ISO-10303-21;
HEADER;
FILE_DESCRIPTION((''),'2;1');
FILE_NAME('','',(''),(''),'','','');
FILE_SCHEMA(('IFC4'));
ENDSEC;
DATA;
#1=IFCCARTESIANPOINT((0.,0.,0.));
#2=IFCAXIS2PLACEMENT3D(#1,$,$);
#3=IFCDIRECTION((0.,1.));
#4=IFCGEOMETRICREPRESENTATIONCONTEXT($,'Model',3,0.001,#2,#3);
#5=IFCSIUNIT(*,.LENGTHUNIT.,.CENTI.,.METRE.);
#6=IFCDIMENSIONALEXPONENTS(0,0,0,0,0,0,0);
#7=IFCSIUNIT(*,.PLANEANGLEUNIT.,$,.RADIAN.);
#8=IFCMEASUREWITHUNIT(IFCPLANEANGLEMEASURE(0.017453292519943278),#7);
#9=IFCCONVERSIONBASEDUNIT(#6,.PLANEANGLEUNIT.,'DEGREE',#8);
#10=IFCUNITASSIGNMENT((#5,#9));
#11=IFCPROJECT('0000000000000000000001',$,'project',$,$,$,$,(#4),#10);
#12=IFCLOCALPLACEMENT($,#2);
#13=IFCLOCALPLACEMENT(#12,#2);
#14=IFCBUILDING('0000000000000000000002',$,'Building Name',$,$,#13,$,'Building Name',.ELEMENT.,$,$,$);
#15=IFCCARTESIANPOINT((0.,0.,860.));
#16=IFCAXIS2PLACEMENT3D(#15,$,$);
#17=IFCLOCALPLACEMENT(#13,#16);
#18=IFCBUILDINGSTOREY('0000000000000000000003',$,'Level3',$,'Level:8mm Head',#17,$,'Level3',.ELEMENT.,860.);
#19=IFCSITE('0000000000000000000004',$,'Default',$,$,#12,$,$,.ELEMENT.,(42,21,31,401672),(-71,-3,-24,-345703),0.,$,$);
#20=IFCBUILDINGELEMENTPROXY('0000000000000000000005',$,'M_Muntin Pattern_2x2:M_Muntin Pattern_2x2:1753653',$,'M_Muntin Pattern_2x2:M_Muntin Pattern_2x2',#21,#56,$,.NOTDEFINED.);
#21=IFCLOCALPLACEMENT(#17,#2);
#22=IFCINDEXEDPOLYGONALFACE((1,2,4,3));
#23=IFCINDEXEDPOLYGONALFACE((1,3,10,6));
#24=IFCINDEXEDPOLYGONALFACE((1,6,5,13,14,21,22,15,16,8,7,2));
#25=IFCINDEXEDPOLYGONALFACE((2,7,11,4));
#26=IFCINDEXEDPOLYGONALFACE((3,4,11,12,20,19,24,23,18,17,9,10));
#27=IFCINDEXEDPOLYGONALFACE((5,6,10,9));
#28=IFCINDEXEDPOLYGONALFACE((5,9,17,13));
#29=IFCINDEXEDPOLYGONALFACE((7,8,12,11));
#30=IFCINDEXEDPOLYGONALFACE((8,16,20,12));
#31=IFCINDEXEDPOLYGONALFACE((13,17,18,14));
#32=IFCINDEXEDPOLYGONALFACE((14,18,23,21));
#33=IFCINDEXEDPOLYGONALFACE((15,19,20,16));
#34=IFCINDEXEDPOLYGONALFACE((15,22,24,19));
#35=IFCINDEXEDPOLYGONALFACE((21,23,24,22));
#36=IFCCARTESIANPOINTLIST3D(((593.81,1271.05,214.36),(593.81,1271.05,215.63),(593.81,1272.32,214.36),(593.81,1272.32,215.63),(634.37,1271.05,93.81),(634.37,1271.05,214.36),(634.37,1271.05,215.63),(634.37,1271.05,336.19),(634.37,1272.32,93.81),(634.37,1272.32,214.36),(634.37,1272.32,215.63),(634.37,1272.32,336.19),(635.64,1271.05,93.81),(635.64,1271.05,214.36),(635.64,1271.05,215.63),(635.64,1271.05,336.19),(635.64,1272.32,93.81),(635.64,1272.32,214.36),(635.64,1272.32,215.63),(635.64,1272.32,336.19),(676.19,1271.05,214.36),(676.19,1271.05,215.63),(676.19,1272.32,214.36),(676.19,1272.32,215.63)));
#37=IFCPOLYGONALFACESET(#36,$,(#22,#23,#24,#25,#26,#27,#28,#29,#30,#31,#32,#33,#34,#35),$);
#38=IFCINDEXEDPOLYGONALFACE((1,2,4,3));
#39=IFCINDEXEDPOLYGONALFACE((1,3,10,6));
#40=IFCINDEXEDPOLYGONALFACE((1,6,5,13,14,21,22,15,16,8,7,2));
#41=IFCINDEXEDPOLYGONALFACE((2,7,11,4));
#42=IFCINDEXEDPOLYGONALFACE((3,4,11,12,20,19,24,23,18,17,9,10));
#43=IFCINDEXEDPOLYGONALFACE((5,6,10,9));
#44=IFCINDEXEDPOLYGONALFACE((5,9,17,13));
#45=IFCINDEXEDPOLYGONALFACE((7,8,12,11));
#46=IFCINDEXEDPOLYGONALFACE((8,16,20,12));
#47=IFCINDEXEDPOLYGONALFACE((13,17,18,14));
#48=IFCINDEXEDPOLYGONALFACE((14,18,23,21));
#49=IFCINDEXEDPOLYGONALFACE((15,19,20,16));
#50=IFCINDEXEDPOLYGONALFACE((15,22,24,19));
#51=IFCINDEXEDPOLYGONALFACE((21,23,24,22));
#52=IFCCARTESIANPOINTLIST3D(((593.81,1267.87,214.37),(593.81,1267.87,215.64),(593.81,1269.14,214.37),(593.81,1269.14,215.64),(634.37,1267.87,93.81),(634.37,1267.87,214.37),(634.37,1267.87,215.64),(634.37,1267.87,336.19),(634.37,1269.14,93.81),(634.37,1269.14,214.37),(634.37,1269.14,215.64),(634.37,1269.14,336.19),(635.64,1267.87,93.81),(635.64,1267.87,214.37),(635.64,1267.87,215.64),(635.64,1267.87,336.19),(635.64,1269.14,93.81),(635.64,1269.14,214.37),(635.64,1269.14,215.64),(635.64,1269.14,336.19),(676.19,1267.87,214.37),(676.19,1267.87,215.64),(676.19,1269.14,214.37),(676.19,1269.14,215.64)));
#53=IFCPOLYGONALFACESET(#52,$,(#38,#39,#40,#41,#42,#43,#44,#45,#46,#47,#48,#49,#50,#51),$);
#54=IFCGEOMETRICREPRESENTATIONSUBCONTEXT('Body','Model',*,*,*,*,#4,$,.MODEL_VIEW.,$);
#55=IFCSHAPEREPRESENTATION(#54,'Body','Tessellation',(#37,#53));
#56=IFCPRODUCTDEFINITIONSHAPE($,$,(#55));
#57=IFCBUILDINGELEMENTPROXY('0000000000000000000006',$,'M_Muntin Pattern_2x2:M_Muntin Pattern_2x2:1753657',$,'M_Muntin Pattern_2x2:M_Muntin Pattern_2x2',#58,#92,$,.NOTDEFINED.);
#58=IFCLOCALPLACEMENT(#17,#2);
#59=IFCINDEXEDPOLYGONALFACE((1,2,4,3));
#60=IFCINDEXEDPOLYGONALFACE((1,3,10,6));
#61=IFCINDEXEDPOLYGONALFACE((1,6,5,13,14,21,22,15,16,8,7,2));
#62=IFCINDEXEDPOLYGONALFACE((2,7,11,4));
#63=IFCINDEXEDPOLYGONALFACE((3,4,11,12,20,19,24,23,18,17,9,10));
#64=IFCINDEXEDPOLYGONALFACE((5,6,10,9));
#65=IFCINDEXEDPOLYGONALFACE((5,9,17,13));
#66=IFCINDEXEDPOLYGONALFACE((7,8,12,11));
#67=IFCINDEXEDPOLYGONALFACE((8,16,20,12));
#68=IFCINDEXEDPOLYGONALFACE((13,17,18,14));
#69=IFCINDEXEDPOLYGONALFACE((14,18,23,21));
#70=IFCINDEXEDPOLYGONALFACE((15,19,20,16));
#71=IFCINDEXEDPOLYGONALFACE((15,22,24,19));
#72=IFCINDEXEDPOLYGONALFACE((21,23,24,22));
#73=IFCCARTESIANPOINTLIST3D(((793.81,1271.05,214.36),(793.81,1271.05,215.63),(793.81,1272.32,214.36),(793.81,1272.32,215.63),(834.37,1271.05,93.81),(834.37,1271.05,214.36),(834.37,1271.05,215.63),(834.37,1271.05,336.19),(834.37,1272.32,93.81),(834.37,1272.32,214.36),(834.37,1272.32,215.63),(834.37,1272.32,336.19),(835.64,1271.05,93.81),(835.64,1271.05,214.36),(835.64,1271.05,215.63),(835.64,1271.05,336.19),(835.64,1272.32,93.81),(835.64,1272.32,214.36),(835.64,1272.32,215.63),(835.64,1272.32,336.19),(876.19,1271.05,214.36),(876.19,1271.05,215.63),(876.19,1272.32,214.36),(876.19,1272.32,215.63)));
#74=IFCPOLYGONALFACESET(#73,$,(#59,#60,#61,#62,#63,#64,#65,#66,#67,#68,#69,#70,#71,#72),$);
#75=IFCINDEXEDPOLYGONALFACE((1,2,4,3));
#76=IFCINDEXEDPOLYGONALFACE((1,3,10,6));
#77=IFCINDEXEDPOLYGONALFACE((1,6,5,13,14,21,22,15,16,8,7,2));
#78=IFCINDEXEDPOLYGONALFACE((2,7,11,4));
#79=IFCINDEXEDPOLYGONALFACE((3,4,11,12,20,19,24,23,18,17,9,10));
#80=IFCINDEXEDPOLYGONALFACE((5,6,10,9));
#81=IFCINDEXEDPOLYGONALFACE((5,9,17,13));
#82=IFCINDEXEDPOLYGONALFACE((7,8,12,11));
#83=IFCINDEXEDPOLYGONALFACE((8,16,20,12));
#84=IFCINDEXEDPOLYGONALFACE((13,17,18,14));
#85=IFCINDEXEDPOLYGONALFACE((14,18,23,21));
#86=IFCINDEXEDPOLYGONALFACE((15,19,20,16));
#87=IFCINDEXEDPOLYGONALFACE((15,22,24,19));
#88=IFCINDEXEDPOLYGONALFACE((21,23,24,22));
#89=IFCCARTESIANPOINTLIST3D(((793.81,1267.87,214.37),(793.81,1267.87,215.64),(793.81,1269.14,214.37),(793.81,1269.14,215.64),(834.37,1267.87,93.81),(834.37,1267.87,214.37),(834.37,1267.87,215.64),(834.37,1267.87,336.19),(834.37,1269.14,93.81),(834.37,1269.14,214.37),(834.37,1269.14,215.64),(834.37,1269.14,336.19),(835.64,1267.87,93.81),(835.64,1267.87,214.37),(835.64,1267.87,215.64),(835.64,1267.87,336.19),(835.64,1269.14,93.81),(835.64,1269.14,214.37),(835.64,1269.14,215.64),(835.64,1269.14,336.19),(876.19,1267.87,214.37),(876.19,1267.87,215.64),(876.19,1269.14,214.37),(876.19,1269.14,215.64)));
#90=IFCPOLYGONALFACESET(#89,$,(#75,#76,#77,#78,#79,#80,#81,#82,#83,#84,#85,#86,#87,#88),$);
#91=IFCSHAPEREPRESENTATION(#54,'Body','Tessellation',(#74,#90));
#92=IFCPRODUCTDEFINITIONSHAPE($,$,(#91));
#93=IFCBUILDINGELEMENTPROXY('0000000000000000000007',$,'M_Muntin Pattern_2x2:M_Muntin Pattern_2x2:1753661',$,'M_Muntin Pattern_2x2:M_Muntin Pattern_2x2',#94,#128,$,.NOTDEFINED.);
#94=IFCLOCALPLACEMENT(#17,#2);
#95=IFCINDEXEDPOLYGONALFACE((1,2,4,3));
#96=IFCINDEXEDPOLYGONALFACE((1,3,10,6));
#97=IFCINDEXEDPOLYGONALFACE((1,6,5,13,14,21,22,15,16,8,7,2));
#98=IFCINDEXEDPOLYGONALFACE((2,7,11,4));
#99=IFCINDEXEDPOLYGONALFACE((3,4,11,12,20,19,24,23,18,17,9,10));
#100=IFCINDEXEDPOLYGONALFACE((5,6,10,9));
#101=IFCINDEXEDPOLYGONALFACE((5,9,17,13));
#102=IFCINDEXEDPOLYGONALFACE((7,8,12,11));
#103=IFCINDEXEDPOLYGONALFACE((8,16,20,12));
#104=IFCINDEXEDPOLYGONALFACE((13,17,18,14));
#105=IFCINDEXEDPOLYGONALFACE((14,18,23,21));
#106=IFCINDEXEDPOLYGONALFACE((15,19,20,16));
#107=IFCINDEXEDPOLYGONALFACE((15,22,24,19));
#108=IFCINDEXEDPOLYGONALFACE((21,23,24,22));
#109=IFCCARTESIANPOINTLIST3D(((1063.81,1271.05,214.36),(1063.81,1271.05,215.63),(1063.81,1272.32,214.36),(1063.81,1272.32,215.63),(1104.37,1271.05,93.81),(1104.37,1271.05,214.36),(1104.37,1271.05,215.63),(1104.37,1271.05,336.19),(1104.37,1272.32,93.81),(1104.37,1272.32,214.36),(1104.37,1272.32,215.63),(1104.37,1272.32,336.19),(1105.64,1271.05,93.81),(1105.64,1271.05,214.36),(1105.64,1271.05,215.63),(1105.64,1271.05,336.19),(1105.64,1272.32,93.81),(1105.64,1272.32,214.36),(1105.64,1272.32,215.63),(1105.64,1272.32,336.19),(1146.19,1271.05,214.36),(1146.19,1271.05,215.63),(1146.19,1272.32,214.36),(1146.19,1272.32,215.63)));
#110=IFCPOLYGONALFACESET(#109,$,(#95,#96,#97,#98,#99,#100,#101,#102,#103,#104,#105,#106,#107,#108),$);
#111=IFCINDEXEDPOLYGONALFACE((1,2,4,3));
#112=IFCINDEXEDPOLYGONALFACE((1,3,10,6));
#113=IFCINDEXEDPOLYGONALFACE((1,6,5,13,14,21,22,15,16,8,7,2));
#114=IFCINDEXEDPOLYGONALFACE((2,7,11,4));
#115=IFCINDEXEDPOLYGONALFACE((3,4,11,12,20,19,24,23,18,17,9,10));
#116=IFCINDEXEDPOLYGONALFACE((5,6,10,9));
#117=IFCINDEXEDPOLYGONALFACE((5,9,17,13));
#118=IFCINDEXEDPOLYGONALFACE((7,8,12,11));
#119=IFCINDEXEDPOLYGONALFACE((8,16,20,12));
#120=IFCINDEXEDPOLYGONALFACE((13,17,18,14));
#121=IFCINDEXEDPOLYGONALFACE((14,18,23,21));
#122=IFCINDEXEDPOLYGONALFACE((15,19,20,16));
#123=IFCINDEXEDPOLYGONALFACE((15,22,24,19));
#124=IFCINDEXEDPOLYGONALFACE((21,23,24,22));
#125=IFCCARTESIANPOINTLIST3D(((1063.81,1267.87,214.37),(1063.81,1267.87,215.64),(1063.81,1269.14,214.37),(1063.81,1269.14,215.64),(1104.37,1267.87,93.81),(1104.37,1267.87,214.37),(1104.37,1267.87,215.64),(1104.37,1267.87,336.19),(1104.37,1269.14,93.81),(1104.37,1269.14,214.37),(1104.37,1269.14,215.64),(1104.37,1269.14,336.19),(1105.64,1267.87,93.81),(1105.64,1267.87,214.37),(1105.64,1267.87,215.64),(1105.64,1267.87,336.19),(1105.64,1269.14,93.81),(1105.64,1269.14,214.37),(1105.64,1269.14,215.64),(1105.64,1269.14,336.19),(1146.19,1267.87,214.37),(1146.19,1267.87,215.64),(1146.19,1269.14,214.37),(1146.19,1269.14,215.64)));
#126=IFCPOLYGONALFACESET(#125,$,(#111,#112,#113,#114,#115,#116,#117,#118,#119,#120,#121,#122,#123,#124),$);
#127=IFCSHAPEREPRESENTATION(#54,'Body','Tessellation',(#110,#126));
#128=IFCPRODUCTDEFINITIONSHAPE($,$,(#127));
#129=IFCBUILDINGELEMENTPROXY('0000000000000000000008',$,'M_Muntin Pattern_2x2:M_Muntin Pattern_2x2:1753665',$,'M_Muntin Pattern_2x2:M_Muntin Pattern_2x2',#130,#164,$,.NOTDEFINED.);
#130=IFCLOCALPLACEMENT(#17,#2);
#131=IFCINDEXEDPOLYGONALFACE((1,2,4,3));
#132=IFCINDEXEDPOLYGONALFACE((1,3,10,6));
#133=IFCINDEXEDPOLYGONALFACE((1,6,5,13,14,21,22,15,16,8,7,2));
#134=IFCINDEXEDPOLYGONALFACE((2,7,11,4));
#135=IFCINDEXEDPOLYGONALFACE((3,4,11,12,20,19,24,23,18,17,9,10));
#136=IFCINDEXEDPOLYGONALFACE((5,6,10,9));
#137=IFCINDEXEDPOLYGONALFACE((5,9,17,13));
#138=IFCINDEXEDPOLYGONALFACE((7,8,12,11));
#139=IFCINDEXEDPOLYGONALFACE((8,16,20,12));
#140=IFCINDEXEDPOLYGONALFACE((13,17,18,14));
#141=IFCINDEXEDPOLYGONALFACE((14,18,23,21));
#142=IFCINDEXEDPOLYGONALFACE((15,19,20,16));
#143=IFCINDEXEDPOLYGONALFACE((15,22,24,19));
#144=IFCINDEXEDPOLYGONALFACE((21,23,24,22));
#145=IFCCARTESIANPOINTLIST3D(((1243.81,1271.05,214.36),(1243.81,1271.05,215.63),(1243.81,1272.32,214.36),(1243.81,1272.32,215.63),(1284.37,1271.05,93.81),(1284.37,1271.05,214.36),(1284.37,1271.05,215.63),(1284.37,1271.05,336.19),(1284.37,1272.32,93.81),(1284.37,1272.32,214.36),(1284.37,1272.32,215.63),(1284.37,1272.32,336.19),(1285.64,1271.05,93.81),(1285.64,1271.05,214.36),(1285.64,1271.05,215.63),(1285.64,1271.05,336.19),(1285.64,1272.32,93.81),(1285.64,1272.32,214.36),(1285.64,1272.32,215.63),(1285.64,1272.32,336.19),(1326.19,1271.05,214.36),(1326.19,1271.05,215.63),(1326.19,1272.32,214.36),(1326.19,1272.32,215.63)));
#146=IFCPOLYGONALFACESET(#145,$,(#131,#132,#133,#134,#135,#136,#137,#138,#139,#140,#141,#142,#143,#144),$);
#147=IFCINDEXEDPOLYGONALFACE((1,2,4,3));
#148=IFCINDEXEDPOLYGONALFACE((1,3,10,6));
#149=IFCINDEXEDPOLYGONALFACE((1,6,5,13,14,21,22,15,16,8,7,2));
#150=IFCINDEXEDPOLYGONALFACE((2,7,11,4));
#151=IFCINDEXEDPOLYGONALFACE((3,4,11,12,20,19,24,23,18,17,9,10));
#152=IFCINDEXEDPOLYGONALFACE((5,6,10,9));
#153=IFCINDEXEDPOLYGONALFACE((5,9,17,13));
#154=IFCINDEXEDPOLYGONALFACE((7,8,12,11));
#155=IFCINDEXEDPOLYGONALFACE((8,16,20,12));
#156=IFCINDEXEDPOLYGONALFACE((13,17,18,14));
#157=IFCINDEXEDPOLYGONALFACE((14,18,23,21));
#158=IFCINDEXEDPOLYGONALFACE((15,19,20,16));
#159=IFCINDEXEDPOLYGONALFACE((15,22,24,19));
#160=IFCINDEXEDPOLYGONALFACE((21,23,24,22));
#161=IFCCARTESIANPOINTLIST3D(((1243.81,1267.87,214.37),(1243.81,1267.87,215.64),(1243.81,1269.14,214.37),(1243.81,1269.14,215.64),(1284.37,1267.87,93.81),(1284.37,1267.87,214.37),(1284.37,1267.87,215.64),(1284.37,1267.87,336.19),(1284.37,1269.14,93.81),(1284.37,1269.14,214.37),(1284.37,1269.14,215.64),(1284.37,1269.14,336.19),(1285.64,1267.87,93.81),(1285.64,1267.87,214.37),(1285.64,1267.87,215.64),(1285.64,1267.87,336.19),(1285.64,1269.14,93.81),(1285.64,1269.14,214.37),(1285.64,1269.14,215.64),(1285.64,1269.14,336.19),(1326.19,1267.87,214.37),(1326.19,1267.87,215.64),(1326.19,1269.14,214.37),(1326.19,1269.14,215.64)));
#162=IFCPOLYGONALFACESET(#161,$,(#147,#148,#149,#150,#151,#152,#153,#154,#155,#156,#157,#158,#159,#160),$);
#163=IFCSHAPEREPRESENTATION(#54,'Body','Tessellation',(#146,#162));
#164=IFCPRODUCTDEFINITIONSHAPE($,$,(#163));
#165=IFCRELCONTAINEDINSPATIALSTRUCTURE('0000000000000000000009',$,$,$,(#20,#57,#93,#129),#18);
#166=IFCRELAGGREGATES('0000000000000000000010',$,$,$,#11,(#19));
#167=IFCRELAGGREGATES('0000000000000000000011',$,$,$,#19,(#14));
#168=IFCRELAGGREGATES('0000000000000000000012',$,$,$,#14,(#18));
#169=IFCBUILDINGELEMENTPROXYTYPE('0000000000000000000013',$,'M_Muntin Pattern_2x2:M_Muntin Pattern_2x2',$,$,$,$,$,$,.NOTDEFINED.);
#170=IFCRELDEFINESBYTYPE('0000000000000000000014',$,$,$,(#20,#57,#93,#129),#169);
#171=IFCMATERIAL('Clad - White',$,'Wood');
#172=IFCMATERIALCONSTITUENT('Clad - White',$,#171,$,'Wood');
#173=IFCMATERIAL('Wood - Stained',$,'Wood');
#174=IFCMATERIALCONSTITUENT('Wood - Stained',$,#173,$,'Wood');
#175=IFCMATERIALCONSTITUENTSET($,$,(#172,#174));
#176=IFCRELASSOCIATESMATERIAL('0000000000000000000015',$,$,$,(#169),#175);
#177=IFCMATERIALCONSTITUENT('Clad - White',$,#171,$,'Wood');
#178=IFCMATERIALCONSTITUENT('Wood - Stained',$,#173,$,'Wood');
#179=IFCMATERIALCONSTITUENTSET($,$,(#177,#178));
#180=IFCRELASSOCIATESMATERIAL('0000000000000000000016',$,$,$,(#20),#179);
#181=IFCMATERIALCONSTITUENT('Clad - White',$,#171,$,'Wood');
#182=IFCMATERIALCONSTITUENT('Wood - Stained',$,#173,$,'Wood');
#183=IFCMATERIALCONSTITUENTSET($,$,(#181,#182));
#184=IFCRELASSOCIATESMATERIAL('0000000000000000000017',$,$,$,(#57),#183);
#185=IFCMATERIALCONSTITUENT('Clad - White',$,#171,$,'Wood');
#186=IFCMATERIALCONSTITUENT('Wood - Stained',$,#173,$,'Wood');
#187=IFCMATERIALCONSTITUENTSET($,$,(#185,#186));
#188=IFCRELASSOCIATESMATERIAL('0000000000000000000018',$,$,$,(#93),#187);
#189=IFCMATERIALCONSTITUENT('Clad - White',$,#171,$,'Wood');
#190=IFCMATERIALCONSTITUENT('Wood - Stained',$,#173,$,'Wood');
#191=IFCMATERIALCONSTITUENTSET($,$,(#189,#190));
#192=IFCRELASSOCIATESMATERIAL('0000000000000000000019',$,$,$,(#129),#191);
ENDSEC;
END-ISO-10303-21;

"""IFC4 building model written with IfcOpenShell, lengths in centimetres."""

from ifc_helpers import new_model, entity, si_unit, converted_unit, direction, frame, origin, place, context, subcontext, project, spatial, indexed_curve, outline, extrude, source, transform, mapped, material, constituent, constituent_set, type_object, type_shapes, element, save


model = new_model("IFC4")

# Units and contexts
model_context = context("Model", 3, precision=0.001, world=origin(), true_north=direction((0.0, 1.0)))
body_context = subcontext(model_context, "Body", "Model", "MODEL_VIEW")
ifc_project = project(units=[si_unit("LENGTHUNIT", "METRE", prefix="CENTI"), converted_unit("PLANEANGLEUNIT", "DEGREE", entity("IfcPlaneAngleMeasure", 0.017453292519943278), si_unit("PLANEANGLEUNIT", "RADIAN"), dimensions=[0, 0, 0, 0, 0, 0, 0])], contexts=[model_context])

# Site, building, storey
site_placement = place(None, origin())
site = spatial("IfcSite", under=ifc_project, at=site_placement, Name="Default", CompositionType="ELEMENT", RefLatitude=(42, 21, 31, 401672), RefLongitude=(-71, -3, -24, -345703), RefElevation=0.0)
building_placement = place(site_placement, origin())
building = spatial("IfcBuilding", under=site, at=building_placement, Name="Building Name", LongName="Building Name", CompositionType="ELEMENT")
storey_placement = place(building_placement, frame((0.0, 0.0, 860.0)))
storey = spatial("IfcBuildingStorey", under=building, at=storey_placement, Name="Level3", ObjectType="Level:8mm Head", LongName="Level3", CompositionType="ELEMENT", Elevation=860.0)

# Building element proxies
ifc_material_1 = material(Name="Clad - White", Category="Wood")
ifc_constituent_1 = constituent(ifc_material_1, Name="Clad - White", Category="Wood")
ifc_material_2 = material(Name="Wood - Stained", Category="Wood")
ifc_constituent_2 = constituent(ifc_material_2, Name="Wood - Stained", Category="Wood")
ifc_constituent_set_1 = constituent_set(constituents=[ifc_constituent_1, ifc_constituent_2])
ifc_constituent_3 = constituent(ifc_material_1, Name="Clad - White", Category="Wood")
ifc_constituent_4 = constituent(ifc_material_2, Name="Wood - Stained", Category="Wood")
ifc_constituent_set_2 = constituent_set(constituents=[ifc_constituent_3, ifc_constituent_4])
building_element_proxy_type_1 = type_object("IfcBuildingElementProxyType", Name="M_Muntin Pattern_2x2:M_Muntin Pattern_2x2", PredefinedType="NOTDEFINED", material=ifc_constituent_set_2)
shared_shape_1 = source(origin(), body_context, "Body", "SweptSolid", [
    extrude(outline(indexed_curve([(0.64, -0.64), (121.19, -0.64), (121.19, 0.63), (0.64, 0.63), (0.64, 41.19), (-0.63, 41.19), (-0.63, 0.63), (-121.19, 0.63), (-121.19, -0.64), (-0.63, -0.64), (-0.63, -41.19), (0.64, -41.19), (0.64, -0.64)], self_intersect=False)), frame((0.0, -2.22, 121.19), z_axis=(0.0, 1.0, 0.0), x_axis=(0.0, 0.0, 1.0)), (0.0, 0.0, 1.0), 1.27),
    extrude(outline(indexed_curve([(0.64, -0.64), (121.19, -0.64), (121.19, 0.63), (0.64, 0.63), (0.64, 41.19), (-0.63, 41.19), (-0.63, 0.63), (-121.19, 0.63), (-121.19, -0.64), (-0.63, -0.64), (-0.63, -41.19), (0.64, -41.19), (0.64, -0.64)], self_intersect=False)), frame((0.0, 0.95, 121.19), z_axis=(0.0, 1.0, 0.0), x_axis=(0.0, 0.0, 1.0)), (0.0, 0.0, 1.0), 1.27),
])
type_shapes(building_element_proxy_type_1, [shared_shape_1])
proxy_1_placement = place(storey_placement, frame((635.0, 1270.1, 93.81), z_axis=(0.0, 0.0, 1.0), x_axis=(-1.0, 0.0, 0.0)))
element("IfcBuildingElementProxy", 1, at=proxy_1_placement, inside=storey, type_object=building_element_proxy_type_1, material=ifc_constituent_set_1, Name="M_Muntin Pattern_2x2:M_Muntin Pattern_2x2:1753653", ObjectType="M_Muntin Pattern_2x2:M_Muntin Pattern_2x2", PredefinedType="NOTDEFINED", context=body_context, shape_type="MappedRepresentation", body=[
    mapped(shared_shape_1, transform((0.0, 0.0, 0.0), scale=1.0)),
])
ifc_constituent_5 = constituent(ifc_material_1, Name="Clad - White", Category="Wood")
ifc_constituent_6 = constituent(ifc_material_2, Name="Wood - Stained", Category="Wood")
ifc_constituent_set_3 = constituent_set(constituents=[ifc_constituent_5, ifc_constituent_6])
proxy_2_placement = place(storey_placement, frame((835.0, 1270.1, 93.81), z_axis=(0.0, 0.0, 1.0), x_axis=(-1.0, 0.0, 0.0)))
element("IfcBuildingElementProxy", 2, at=proxy_2_placement, inside=storey, type_object=building_element_proxy_type_1, material=ifc_constituent_set_3, Name="M_Muntin Pattern_2x2:M_Muntin Pattern_2x2:1753657", ObjectType="M_Muntin Pattern_2x2:M_Muntin Pattern_2x2", PredefinedType="NOTDEFINED", context=body_context, shape_type="MappedRepresentation", body=[
    mapped(shared_shape_1, transform((0.0, 0.0, 0.0), scale=1.0)),
])
ifc_constituent_7 = constituent(ifc_material_1, Name="Clad - White", Category="Wood")
ifc_constituent_8 = constituent(ifc_material_2, Name="Wood - Stained", Category="Wood")
ifc_constituent_set_4 = constituent_set(constituents=[ifc_constituent_7, ifc_constituent_8])
proxy_3_placement = place(storey_placement, frame((1105.0, 1270.1, 93.81), z_axis=(0.0, 0.0, 1.0), x_axis=(-1.0, 0.0, 0.0)))
element("IfcBuildingElementProxy", 3, at=proxy_3_placement, inside=storey, type_object=building_element_proxy_type_1, material=ifc_constituent_set_4, Name="M_Muntin Pattern_2x2:M_Muntin Pattern_2x2:1753661", ObjectType="M_Muntin Pattern_2x2:M_Muntin Pattern_2x2", PredefinedType="NOTDEFINED", context=body_context, shape_type="MappedRepresentation", body=[
    mapped(shared_shape_1, transform((0.0, 0.0, 0.0), scale=1.0)),
])
ifc_constituent_9 = constituent(ifc_material_1, Name="Clad - White", Category="Wood")
ifc_constituent_10 = constituent(ifc_material_2, Name="Wood - Stained", Category="Wood")
ifc_constituent_set_5 = constituent_set(constituents=[ifc_constituent_9, ifc_constituent_10])
proxy_4_placement = place(storey_placement, frame((1285.0, 1270.1, 93.81), z_axis=(0.0, 0.0, 1.0), x_axis=(-1.0, 0.0, 0.0)))
element("IfcBuildingElementProxy", 4, at=proxy_4_placement, inside=storey, type_object=building_element_proxy_type_1, material=ifc_constituent_set_5, Name="M_Muntin Pattern_2x2:M_Muntin Pattern_2x2:1753665", ObjectType="M_Muntin Pattern_2x2:M_Muntin Pattern_2x2", PredefinedType="NOTDEFINED", context=body_context, shape_type="MappedRepresentation", body=[
    mapped(shared_shape_1, transform((0.0, 0.0, 0.0), scale=1.0)),
])

save(model, "model.ifc")
